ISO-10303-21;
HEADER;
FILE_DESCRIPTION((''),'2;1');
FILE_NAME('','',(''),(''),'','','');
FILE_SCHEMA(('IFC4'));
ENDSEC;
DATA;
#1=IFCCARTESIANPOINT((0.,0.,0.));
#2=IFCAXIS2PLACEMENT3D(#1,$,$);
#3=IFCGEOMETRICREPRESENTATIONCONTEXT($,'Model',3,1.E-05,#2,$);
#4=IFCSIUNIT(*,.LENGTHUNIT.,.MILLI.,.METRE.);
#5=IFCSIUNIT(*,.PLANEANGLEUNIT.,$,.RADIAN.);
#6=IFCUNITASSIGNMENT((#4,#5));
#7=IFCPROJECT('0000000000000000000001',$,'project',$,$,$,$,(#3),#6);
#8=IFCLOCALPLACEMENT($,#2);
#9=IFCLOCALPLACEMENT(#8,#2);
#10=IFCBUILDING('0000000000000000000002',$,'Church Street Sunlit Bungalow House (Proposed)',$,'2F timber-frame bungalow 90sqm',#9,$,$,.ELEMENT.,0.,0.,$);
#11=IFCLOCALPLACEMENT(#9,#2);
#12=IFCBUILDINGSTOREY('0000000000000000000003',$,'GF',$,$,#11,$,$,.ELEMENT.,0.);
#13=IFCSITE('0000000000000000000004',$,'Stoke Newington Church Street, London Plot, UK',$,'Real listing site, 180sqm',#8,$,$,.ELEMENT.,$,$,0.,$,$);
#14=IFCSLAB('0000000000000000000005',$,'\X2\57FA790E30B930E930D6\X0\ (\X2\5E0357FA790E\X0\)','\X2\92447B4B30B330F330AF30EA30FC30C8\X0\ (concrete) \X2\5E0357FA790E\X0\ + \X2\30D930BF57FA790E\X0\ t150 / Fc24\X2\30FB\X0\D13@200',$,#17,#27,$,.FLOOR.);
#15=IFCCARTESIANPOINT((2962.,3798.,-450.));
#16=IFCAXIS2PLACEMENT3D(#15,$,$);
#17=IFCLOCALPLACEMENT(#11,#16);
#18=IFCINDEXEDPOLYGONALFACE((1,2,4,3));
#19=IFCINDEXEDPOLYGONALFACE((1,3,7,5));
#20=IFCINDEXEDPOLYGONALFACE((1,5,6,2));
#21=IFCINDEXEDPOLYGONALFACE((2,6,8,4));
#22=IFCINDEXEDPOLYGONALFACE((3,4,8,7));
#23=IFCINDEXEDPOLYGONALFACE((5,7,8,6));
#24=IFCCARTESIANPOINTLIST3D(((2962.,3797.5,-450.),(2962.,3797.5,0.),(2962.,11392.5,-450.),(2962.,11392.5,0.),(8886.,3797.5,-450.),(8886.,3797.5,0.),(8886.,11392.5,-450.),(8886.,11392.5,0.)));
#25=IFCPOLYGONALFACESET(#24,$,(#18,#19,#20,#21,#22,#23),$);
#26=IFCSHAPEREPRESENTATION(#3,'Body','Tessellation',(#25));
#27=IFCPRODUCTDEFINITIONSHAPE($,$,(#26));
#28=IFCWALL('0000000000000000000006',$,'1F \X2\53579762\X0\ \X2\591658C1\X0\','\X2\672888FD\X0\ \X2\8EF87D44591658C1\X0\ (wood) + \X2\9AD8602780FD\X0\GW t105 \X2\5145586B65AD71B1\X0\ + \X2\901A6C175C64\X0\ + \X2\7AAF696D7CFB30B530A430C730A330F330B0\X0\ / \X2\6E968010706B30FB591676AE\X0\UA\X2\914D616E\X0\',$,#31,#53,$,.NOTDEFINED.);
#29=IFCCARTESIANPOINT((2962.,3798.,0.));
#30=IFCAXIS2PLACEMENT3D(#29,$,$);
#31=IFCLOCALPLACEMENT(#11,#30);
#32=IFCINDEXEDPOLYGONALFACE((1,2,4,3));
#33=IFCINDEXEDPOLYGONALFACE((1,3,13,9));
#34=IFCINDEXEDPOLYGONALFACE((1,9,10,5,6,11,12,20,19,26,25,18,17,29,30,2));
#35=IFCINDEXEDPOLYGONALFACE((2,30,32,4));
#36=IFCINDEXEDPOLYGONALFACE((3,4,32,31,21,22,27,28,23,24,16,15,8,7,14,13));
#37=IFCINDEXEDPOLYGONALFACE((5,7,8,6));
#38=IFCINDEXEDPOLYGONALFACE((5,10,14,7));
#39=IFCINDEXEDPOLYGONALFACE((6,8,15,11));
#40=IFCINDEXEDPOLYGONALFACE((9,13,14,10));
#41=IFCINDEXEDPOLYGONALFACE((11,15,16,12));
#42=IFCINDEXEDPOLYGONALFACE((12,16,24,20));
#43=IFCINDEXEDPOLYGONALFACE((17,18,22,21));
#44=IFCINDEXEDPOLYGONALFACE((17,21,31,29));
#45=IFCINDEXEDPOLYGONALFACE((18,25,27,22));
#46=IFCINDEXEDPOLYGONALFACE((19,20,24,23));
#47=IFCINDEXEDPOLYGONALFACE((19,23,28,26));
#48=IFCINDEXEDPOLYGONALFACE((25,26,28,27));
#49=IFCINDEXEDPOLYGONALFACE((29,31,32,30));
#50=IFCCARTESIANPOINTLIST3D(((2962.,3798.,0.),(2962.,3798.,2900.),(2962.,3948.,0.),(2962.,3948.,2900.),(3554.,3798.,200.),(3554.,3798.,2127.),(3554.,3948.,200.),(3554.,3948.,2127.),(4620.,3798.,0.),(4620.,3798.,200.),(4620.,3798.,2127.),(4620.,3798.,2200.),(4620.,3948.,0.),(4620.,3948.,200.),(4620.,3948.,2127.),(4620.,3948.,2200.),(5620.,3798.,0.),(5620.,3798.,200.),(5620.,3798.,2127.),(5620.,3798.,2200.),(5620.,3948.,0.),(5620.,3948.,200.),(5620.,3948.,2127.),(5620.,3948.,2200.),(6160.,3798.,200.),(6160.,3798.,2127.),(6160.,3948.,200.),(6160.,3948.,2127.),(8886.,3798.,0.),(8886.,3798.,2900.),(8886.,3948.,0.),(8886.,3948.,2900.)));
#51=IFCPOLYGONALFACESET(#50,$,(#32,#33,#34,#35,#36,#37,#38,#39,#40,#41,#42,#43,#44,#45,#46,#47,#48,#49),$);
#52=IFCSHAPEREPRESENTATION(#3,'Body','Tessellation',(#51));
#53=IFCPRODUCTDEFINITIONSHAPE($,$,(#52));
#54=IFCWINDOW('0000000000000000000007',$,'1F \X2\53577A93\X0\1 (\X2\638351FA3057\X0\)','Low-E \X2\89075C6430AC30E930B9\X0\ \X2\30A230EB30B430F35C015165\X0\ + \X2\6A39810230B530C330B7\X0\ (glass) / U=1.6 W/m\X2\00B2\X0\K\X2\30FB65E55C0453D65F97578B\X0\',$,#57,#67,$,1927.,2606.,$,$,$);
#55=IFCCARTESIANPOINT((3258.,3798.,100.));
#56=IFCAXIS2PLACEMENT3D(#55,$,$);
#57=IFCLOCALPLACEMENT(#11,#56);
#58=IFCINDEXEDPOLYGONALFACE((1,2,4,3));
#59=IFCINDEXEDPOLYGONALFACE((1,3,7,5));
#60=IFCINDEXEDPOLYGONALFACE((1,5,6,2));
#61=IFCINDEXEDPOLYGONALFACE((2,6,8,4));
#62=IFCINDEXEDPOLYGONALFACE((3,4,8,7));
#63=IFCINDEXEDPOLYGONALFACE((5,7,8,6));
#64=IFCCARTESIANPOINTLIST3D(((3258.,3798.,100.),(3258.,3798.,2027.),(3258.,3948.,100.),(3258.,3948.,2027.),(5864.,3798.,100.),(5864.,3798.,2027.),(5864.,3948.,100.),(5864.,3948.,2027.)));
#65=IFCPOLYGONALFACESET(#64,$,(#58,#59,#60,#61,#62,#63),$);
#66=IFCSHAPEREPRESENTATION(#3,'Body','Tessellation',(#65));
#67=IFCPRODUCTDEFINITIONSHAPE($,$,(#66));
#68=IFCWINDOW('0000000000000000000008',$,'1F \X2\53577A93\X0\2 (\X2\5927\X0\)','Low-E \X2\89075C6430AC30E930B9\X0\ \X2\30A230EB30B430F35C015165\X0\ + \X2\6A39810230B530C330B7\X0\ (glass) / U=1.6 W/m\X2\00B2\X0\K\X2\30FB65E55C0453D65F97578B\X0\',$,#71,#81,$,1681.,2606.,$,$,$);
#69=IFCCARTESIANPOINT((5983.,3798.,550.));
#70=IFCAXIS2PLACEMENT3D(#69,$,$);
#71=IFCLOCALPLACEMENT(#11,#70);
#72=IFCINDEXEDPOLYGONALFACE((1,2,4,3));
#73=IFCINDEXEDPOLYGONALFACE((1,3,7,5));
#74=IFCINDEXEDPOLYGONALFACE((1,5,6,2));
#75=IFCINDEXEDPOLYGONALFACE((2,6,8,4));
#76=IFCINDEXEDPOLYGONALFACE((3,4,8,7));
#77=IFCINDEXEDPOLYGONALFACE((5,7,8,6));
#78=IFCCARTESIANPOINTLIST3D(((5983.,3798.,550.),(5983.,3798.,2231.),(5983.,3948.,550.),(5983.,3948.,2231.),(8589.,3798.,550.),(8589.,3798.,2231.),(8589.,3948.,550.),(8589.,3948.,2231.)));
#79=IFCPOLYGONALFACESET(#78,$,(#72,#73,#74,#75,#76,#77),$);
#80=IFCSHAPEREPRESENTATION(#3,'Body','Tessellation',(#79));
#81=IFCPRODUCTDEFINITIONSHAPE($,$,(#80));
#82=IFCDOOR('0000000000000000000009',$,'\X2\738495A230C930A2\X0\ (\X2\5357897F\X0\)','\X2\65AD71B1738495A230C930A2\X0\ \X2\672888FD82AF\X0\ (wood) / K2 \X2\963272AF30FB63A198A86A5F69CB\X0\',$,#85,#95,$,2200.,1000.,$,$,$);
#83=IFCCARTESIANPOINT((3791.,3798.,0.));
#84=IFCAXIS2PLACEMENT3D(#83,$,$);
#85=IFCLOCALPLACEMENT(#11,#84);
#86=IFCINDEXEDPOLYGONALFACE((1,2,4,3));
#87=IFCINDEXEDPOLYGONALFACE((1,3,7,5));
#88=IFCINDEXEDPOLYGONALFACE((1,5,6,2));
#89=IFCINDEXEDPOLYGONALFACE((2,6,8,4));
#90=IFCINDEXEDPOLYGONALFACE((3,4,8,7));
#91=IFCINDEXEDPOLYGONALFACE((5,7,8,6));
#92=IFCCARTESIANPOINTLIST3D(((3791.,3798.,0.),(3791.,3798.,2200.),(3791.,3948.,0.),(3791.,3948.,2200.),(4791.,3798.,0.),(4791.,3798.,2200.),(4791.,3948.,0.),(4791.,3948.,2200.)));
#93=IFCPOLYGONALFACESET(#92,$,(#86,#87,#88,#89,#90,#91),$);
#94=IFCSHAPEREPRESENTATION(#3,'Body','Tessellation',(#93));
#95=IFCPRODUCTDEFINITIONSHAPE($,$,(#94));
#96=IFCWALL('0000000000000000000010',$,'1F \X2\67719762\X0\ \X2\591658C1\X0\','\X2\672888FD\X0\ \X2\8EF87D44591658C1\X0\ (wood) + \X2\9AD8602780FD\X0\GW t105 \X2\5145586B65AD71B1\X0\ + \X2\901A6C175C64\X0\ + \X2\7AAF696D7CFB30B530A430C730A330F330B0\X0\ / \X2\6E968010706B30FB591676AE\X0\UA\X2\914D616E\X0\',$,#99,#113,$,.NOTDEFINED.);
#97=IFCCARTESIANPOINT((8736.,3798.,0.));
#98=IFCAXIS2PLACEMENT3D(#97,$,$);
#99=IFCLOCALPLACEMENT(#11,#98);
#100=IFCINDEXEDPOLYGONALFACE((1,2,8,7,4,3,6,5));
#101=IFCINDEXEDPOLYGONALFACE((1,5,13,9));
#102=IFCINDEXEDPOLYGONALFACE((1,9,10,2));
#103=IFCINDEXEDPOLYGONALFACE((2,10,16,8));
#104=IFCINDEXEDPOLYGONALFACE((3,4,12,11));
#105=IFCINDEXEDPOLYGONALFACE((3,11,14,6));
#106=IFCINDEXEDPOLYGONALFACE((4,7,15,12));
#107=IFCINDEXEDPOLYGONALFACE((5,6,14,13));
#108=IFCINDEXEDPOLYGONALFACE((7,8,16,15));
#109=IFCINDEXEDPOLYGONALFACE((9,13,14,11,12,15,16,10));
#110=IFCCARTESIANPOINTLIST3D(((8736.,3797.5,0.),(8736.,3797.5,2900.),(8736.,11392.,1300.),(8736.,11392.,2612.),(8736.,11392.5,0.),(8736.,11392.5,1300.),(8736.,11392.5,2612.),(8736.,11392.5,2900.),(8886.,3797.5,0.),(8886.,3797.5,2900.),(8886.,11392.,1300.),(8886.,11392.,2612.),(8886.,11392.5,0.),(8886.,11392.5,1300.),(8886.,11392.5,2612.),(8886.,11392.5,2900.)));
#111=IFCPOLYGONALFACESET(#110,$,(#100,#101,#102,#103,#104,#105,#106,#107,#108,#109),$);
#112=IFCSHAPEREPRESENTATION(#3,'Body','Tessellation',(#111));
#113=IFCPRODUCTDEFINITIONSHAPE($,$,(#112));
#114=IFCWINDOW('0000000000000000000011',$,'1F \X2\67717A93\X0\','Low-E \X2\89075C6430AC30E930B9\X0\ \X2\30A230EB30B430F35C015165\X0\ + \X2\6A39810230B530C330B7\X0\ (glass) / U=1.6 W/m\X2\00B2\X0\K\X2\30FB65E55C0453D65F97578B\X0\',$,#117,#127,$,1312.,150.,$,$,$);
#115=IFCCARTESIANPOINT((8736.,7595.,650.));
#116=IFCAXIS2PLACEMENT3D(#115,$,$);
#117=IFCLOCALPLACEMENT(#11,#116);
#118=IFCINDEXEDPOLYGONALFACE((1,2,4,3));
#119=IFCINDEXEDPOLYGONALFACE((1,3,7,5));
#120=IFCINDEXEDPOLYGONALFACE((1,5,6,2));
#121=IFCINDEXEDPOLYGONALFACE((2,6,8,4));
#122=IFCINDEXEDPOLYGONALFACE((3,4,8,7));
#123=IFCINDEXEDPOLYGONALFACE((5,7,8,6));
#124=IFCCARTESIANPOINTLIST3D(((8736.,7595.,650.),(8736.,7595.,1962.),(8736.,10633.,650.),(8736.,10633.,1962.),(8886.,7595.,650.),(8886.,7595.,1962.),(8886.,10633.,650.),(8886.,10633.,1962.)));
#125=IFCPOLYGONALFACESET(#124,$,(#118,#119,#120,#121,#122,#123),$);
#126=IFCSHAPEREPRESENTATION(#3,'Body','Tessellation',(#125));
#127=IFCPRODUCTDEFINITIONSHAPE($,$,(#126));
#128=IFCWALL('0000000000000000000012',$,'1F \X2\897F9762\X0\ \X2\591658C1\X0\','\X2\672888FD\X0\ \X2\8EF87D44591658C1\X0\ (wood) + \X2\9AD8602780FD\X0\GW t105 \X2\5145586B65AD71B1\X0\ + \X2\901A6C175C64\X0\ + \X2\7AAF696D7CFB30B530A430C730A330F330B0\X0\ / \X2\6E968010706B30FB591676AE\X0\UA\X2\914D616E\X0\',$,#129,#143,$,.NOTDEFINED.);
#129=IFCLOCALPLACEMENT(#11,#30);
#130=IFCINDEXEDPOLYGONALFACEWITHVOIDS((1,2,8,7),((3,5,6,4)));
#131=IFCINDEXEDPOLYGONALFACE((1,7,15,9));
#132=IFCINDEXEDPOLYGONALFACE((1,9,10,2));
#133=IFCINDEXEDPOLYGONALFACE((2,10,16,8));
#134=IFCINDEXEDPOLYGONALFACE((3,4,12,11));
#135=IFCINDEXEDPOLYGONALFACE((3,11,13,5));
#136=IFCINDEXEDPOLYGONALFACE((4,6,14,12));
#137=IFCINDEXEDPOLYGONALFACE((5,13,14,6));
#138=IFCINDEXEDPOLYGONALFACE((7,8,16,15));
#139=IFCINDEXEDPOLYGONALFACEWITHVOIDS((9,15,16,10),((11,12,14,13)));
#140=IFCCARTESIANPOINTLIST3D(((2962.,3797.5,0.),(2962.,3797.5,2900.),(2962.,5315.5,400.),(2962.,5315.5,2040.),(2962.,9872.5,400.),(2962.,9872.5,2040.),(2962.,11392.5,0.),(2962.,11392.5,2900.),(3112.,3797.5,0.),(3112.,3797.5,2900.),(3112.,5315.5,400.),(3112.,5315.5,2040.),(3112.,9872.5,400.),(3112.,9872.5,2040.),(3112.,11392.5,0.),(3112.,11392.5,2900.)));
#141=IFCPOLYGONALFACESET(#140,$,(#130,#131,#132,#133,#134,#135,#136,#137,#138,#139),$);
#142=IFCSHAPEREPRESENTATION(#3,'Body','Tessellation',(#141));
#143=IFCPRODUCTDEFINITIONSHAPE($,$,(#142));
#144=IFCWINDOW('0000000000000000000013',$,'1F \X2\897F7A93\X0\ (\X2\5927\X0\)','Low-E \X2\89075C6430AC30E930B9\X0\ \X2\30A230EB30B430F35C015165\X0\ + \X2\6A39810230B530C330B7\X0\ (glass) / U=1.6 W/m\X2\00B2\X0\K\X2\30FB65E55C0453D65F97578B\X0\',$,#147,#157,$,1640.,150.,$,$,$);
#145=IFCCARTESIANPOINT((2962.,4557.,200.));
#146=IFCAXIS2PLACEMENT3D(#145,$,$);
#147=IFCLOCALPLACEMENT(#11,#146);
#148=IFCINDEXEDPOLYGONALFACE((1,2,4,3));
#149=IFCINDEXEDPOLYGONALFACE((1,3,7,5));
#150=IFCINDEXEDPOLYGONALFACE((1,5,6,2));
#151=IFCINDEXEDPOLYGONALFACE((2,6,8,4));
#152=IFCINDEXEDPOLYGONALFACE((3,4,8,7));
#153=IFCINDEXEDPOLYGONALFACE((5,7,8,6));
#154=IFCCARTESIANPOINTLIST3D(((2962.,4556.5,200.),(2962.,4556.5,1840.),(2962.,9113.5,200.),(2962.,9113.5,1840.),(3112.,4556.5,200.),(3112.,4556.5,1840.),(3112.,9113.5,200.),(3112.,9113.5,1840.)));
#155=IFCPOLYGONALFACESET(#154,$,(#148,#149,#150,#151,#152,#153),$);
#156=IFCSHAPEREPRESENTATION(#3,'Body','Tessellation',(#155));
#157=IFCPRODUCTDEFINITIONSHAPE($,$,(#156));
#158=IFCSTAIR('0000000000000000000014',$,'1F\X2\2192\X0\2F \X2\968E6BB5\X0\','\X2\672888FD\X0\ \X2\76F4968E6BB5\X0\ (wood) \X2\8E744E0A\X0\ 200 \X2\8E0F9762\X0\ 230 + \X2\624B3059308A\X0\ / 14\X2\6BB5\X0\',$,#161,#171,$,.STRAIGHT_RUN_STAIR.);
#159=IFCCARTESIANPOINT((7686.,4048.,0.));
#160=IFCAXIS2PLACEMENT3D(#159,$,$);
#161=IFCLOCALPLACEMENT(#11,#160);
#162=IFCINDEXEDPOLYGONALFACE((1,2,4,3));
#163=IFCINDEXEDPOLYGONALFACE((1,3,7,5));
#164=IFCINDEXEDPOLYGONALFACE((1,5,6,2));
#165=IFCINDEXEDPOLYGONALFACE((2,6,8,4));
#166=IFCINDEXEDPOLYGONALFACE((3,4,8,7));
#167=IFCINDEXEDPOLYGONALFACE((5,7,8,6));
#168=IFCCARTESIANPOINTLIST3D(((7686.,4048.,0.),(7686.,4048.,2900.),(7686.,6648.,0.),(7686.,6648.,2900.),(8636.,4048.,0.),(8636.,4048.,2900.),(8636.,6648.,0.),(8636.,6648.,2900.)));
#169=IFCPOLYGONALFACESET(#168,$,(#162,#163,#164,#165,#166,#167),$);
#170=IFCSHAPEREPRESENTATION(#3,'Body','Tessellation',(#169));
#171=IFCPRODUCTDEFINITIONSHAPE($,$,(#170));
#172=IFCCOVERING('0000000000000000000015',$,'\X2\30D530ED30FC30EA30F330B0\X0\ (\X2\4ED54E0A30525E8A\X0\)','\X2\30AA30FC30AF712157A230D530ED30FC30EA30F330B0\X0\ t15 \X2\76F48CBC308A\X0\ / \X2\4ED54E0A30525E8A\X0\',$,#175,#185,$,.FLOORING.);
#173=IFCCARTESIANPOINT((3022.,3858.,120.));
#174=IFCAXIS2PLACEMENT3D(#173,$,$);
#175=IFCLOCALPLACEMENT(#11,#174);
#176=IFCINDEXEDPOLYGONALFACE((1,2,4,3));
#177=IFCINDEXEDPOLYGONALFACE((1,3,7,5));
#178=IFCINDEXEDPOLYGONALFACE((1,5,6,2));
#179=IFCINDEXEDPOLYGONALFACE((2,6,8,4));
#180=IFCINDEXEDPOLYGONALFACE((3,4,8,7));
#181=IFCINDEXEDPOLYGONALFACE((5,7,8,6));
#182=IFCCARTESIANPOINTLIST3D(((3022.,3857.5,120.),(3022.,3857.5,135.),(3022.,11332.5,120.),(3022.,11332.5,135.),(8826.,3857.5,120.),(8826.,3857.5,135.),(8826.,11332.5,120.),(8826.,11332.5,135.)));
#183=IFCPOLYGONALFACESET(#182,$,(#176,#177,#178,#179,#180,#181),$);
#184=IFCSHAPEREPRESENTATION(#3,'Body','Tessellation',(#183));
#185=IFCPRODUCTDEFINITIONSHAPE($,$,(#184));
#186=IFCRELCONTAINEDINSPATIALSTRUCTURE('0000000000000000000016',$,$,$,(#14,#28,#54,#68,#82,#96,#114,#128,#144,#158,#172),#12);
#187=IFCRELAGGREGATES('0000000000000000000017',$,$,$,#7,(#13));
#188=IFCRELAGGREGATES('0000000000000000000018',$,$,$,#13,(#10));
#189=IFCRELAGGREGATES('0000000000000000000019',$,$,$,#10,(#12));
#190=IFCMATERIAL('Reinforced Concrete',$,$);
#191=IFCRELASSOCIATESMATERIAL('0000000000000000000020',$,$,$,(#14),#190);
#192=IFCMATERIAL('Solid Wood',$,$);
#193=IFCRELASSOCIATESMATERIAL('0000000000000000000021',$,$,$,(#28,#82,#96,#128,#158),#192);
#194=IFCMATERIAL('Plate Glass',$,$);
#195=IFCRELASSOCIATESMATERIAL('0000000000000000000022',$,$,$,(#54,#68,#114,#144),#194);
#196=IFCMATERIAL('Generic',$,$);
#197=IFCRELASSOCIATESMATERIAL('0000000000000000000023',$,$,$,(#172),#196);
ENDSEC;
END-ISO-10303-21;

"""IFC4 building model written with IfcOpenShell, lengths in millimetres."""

from ifc_helpers import new_model, si_unit, frame, frame_2d, origin, place, context, project, spatial, rectangle, extrude, material, element, fill, save


model = new_model("IFC4")

# Units and contexts
model_context = context("Model", 3, precision=1e-05, world=origin())
ifc_project = project(units=[si_unit("LENGTHUNIT", "METRE", prefix="MILLI"), si_unit("PLANEANGLEUNIT", "RADIAN")], contexts=[model_context])

# Site, building, storey
site_placement = place(None, origin())
site = spatial("IfcSite", under=ifc_project, at=site_placement, Name="Stoke Newington Church Street, London Plot, UK", ObjectType="Real listing site, 180sqm", CompositionType="ELEMENT", RefElevation=0.0)
building_placement = place(site_placement, origin())
building = spatial("IfcBuilding", under=site, at=building_placement, Name="Church Street Sunlit Bungalow House (Proposed)", ObjectType="2F timber-frame bungalow 90sqm", CompositionType="ELEMENT", ElevationOfRefHeight=0.0, ElevationOfTerrain=0.0)
storey_placement = place(building_placement, origin())
storey = spatial("IfcBuildingStorey", under=building, at=storey_placement, Name="GF", CompositionType="ELEMENT", Elevation=0.0)

# Slab
ifc_material_1 = material(Name="Reinforced Concrete")
slab_1_placement = place(storey_placement, frame((2962.0, 3798.0, -450.0)))
element("IfcSlab", 1, at=slab_1_placement, inside=storey, material=ifc_material_1, Name="基礎スラブ (布基礎)", Description="鉄筋コンクリート (concrete) 布基礎 + ベタ基礎 t150 / Fc24・D13@200", PredefinedType="FLOOR", context=model_context, shape_type="SweptSolid", body=[
    extrude(rectangle(XDim=5924.0, YDim=7595.0, at=frame_2d((2962.0, 3797.0))), frame((2962.0, 3798.0, -450.0)), (0.0, 0.0, 1.0), 450.0),
])
ifc_material_2 = material(Name="Solid Wood")

# Wall, openings, windows, door
wall_1_placement = place(storey_placement, frame((2962.0, 3798.0, 0.0)))
wall_1 = element("IfcWall", 2, at=wall_1_placement, inside=storey, material=ifc_material_2, Name="1F 南面 外壁", Description="木製 軸組外壁 (wood) + 高性能GW t105 充填断熱 + 通気層 + 窯業系サイディング / 準耐火・外皮UA配慮", PredefinedType="NOTDEFINED", context=model_context, shape_type="SweptSolid", body=[
    extrude(rectangle(XDim=5924.0, YDim=150.0, at=frame_2d((2962.0, 75.0))), frame((2962.0, 3798.0, 0.0)), (0.0, 0.0, 1.0), 2900.0),
])
opening_1_placement = place(storey_placement, frame((3258.0, 3798.0, 100.0)))
opening_1 = element("IfcOpeningElement", 3, at=opening_1_placement, cuts=wall_1, PredefinedType="NOTDEFINED", context=model_context, shape_type="SweptSolid", body=[
    extrude(rectangle(XDim=2606.0, YDim=150.0, at=frame_2d((1303.0, 75.0))), frame((3258.0, 3798.0, 100.0)), (0.0, 0.0, 1.0), 1927.0),
])
opening_2_placement = place(storey_placement, frame((5983.0, 3798.0, 550.0)))
opening_2 = element("IfcOpeningElement", 4, at=opening_2_placement, cuts=wall_1, PredefinedType="NOTDEFINED", context=model_context, shape_type="SweptSolid", body=[
    extrude(rectangle(XDim=2606.0, YDim=150.0, at=frame_2d((1303.0, 75.0))), frame((5983.0, 3798.0, 550.0)), (0.0, 0.0, 1.0), 1681.0),
])
opening_3_placement = place(storey_placement, frame((3791.0, 3798.0, 0.0)))
opening_3 = element("IfcOpeningElement", 5, at=opening_3_placement, cuts=wall_1, PredefinedType="NOTDEFINED", context=model_context, shape_type="SweptSolid", body=[
    extrude(rectangle(XDim=1000.0, YDim=150.0, at=frame_2d((500.0, 75.0))), frame((3791.0, 3798.0, 0.0)), (0.0, 0.0, 1.0), 2200.0),
])
ifc_material_3 = material(Name="Plate Glass")
window_1_placement = place(storey_placement, frame((3258.0, 3798.0, 100.0)))
window_1 = element("IfcWindow", 6, at=window_1_placement, inside=storey, material=ifc_material_3, Name="1F 南窓1 (掃出し)", Description="Low-E 複層ガラス アルゴン封入 + 樹脂サッシ (glass) / U=1.6 W/m²K・日射取得型", OverallHeight=1927.0, OverallWidth=2606.0, context=model_context, shape_type="SweptSolid", body=[
    extrude(rectangle(XDim=2606.0, YDim=150.0, at=frame_2d((1303.0, 75.0))), frame((3258.0, 3798.0, 100.0)), (0.0, 0.0, 1.0), 1927.0),
])
fill(opening_1, window_1)
window_2_placement = place(storey_placement, frame((5983.0, 3798.0, 550.0)))
window_2 = element("IfcWindow", 7, at=window_2_placement, inside=storey, material=ifc_material_3, Name="1F 南窓2 (大)", Description="Low-E 複層ガラス アルゴン封入 + 樹脂サッシ (glass) / U=1.6 W/m²K・日射取得型", OverallHeight=1681.0, OverallWidth=2606.0, context=model_context, shape_type="SweptSolid", body=[
    extrude(rectangle(XDim=2606.0, YDim=150.0, at=frame_2d((1303.0, 75.0))), frame((5983.0, 3798.0, 550.0)), (0.0, 0.0, 1.0), 1681.0),
])
fill(opening_2, window_2)
door_placement = place(storey_placement, frame((3791.0, 3798.0, 0.0)))
door = element("IfcDoor", 8, at=door_placement, inside=storey, material=ifc_material_2, Name="玄関ドア (南西)", Description="断熱玄関ドア 木製芯 (wood) / K2 防犯・採風機構", OverallHeight=2200.0, OverallWidth=1000.0, context=model_context, shape_type="SweptSolid", body=[
    extrude(rectangle(XDim=1000.0, YDim=150.0, at=frame_2d((500.0, 75.0))), frame((3791.0, 3798.0, 0.0)), (0.0, 0.0, 1.0), 2200.0),
])
fill(opening_3, door)

# Walls, openings, windows
wall_2_placement = place(storey_placement, frame((8736.0, 3798.0, 0.0)))
wall_2 = element("IfcWall", 9, at=wall_2_placement, inside=storey, material=ifc_material_2, Name="1F 東面 外壁", Description="木製 軸組外壁 (wood) + 高性能GW t105 充填断熱 + 通気層 + 窯業系サイディング / 準耐火・外皮UA配慮", PredefinedType="NOTDEFINED", context=model_context, shape_type="SweptSolid", body=[
    extrude(rectangle(XDim=150.0, YDim=7595.0, at=frame_2d((75.0, 3797.0))), frame((8736.0, 3798.0, 0.0)), (0.0, 0.0, 1.0), 2900.0),
])
opening_4_placement = place(storey_placement, frame((8736.0, 7595.0, 650.0)))
opening_4 = element("IfcOpeningElement", 10, at=opening_4_placement, cuts=wall_2, PredefinedType="NOTDEFINED", context=model_context, shape_type="SweptSolid", body=[
    extrude(rectangle(XDim=150.0, YDim=3038.0, at=frame_2d((75.0, 1519.0))), frame((8736.0, 7595.0, 650.0)), (0.0, 0.0, 1.0), 1312.0),
])
window_3_placement = place(storey_placement, frame((8736.0, 7595.0, 650.0)))
window_3 = element("IfcWindow", 11, at=window_3_placement, inside=storey, material=ifc_material_3, Name="1F 東窓", Description="Low-E 複層ガラス アルゴン封入 + 樹脂サッシ (glass) / U=1.6 W/m²K・日射取得型", OverallHeight=1312.0, OverallWidth=150.0, context=model_context, shape_type="SweptSolid", body=[
    extrude(rectangle(XDim=150.0, YDim=3038.0, at=frame_2d((75.0, 1519.0))), frame((8736.0, 7595.0, 650.0)), (0.0, 0.0, 1.0), 1312.0),
])
fill(opening_4, window_3)
wall_3_placement = place(storey_placement, frame((2962.0, 3798.0, 0.0)))
wall_3 = element("IfcWall", 12, at=wall_3_placement, inside=storey, material=ifc_material_2, Name="1F 西面 外壁", Description="木製 軸組外壁 (wood) + 高性能GW t105 充填断熱 + 通気層 + 窯業系サイディング / 準耐火・外皮UA配慮", PredefinedType="NOTDEFINED", context=model_context, shape_type="SweptSolid", body=[
    extrude(rectangle(XDim=150.0, YDim=7595.0, at=frame_2d((75.0, 3797.0))), frame((2962.0, 3798.0, 0.0)), (0.0, 0.0, 1.0), 2900.0),
])
opening_5_placement = place(storey_placement, frame((2962.0, 4557.0, 200.0)))
opening_5 = element("IfcOpeningElement", 13, at=opening_5_placement, cuts=wall_3, PredefinedType="NOTDEFINED", context=model_context, shape_type="SweptSolid", body=[
    extrude(rectangle(XDim=150.0, YDim=4557.0, at=frame_2d((75.0, 2278.0))), frame((2962.0, 4557.0, 200.0)), (0.0, 0.0, 1.0), 1640.0),
])
window_4_placement = place(storey_placement, frame((2962.0, 4557.0, 200.0)))
window_4 = element("IfcWindow", 14, at=window_4_placement, inside=storey, material=ifc_material_3, Name="1F 西窓 (大)", Description="Low-E 複層ガラス アルゴン封入 + 樹脂サッシ (glass) / U=1.6 W/m²K・日射取得型", OverallHeight=1640.0, OverallWidth=150.0, context=model_context, shape_type="SweptSolid", body=[
    extrude(rectangle(XDim=150.0, YDim=4557.0, at=frame_2d((75.0, 2278.0))), frame((2962.0, 4557.0, 200.0)), (0.0, 0.0, 1.0), 1640.0),
])
fill(opening_5, window_4)

# Stair
stair_placement = place(storey_placement, frame((7686.0, 4048.0, 0.0)))
element("IfcStair", 15, at=stair_placement, inside=storey, material=ifc_material_2, Name="1F→2F 階段", Description="木製 直階段 (wood) 蹴上 200 踏面 230 + 手すり / 14段", PredefinedType="STRAIGHT_RUN_STAIR", context=model_context, shape_type="SweptSolid", body=[
    extrude(rectangle(XDim=950.0, YDim=2600.0, at=frame_2d((475.0, 1300.0))), frame((7686.0, 4048.0, 0.0)), (0.0, 0.0, 1.0), 2900.0),
])

# Covering
ifc_material_4 = material(Name="Generic")
covering_placement = place(storey_placement, frame((3022.0, 3858.0, 120.0)))
element("IfcCovering", 16, at=covering_placement, inside=storey, material=ifc_material_4, Name="フローリング (仕上げ床)", Description="オーク無垢フローリング t15 直貼り / 仕上げ床", PredefinedType="FLOORING", context=model_context, shape_type="SweptSolid", body=[
    extrude(rectangle(XDim=5804.0, YDim=7475.0, at=frame_2d((2902.0, 3737.0))), frame((3022.0, 3858.0, 120.0)), (0.0, 0.0, 1.0), 15.0),
])

save(model, "model.ifc")
